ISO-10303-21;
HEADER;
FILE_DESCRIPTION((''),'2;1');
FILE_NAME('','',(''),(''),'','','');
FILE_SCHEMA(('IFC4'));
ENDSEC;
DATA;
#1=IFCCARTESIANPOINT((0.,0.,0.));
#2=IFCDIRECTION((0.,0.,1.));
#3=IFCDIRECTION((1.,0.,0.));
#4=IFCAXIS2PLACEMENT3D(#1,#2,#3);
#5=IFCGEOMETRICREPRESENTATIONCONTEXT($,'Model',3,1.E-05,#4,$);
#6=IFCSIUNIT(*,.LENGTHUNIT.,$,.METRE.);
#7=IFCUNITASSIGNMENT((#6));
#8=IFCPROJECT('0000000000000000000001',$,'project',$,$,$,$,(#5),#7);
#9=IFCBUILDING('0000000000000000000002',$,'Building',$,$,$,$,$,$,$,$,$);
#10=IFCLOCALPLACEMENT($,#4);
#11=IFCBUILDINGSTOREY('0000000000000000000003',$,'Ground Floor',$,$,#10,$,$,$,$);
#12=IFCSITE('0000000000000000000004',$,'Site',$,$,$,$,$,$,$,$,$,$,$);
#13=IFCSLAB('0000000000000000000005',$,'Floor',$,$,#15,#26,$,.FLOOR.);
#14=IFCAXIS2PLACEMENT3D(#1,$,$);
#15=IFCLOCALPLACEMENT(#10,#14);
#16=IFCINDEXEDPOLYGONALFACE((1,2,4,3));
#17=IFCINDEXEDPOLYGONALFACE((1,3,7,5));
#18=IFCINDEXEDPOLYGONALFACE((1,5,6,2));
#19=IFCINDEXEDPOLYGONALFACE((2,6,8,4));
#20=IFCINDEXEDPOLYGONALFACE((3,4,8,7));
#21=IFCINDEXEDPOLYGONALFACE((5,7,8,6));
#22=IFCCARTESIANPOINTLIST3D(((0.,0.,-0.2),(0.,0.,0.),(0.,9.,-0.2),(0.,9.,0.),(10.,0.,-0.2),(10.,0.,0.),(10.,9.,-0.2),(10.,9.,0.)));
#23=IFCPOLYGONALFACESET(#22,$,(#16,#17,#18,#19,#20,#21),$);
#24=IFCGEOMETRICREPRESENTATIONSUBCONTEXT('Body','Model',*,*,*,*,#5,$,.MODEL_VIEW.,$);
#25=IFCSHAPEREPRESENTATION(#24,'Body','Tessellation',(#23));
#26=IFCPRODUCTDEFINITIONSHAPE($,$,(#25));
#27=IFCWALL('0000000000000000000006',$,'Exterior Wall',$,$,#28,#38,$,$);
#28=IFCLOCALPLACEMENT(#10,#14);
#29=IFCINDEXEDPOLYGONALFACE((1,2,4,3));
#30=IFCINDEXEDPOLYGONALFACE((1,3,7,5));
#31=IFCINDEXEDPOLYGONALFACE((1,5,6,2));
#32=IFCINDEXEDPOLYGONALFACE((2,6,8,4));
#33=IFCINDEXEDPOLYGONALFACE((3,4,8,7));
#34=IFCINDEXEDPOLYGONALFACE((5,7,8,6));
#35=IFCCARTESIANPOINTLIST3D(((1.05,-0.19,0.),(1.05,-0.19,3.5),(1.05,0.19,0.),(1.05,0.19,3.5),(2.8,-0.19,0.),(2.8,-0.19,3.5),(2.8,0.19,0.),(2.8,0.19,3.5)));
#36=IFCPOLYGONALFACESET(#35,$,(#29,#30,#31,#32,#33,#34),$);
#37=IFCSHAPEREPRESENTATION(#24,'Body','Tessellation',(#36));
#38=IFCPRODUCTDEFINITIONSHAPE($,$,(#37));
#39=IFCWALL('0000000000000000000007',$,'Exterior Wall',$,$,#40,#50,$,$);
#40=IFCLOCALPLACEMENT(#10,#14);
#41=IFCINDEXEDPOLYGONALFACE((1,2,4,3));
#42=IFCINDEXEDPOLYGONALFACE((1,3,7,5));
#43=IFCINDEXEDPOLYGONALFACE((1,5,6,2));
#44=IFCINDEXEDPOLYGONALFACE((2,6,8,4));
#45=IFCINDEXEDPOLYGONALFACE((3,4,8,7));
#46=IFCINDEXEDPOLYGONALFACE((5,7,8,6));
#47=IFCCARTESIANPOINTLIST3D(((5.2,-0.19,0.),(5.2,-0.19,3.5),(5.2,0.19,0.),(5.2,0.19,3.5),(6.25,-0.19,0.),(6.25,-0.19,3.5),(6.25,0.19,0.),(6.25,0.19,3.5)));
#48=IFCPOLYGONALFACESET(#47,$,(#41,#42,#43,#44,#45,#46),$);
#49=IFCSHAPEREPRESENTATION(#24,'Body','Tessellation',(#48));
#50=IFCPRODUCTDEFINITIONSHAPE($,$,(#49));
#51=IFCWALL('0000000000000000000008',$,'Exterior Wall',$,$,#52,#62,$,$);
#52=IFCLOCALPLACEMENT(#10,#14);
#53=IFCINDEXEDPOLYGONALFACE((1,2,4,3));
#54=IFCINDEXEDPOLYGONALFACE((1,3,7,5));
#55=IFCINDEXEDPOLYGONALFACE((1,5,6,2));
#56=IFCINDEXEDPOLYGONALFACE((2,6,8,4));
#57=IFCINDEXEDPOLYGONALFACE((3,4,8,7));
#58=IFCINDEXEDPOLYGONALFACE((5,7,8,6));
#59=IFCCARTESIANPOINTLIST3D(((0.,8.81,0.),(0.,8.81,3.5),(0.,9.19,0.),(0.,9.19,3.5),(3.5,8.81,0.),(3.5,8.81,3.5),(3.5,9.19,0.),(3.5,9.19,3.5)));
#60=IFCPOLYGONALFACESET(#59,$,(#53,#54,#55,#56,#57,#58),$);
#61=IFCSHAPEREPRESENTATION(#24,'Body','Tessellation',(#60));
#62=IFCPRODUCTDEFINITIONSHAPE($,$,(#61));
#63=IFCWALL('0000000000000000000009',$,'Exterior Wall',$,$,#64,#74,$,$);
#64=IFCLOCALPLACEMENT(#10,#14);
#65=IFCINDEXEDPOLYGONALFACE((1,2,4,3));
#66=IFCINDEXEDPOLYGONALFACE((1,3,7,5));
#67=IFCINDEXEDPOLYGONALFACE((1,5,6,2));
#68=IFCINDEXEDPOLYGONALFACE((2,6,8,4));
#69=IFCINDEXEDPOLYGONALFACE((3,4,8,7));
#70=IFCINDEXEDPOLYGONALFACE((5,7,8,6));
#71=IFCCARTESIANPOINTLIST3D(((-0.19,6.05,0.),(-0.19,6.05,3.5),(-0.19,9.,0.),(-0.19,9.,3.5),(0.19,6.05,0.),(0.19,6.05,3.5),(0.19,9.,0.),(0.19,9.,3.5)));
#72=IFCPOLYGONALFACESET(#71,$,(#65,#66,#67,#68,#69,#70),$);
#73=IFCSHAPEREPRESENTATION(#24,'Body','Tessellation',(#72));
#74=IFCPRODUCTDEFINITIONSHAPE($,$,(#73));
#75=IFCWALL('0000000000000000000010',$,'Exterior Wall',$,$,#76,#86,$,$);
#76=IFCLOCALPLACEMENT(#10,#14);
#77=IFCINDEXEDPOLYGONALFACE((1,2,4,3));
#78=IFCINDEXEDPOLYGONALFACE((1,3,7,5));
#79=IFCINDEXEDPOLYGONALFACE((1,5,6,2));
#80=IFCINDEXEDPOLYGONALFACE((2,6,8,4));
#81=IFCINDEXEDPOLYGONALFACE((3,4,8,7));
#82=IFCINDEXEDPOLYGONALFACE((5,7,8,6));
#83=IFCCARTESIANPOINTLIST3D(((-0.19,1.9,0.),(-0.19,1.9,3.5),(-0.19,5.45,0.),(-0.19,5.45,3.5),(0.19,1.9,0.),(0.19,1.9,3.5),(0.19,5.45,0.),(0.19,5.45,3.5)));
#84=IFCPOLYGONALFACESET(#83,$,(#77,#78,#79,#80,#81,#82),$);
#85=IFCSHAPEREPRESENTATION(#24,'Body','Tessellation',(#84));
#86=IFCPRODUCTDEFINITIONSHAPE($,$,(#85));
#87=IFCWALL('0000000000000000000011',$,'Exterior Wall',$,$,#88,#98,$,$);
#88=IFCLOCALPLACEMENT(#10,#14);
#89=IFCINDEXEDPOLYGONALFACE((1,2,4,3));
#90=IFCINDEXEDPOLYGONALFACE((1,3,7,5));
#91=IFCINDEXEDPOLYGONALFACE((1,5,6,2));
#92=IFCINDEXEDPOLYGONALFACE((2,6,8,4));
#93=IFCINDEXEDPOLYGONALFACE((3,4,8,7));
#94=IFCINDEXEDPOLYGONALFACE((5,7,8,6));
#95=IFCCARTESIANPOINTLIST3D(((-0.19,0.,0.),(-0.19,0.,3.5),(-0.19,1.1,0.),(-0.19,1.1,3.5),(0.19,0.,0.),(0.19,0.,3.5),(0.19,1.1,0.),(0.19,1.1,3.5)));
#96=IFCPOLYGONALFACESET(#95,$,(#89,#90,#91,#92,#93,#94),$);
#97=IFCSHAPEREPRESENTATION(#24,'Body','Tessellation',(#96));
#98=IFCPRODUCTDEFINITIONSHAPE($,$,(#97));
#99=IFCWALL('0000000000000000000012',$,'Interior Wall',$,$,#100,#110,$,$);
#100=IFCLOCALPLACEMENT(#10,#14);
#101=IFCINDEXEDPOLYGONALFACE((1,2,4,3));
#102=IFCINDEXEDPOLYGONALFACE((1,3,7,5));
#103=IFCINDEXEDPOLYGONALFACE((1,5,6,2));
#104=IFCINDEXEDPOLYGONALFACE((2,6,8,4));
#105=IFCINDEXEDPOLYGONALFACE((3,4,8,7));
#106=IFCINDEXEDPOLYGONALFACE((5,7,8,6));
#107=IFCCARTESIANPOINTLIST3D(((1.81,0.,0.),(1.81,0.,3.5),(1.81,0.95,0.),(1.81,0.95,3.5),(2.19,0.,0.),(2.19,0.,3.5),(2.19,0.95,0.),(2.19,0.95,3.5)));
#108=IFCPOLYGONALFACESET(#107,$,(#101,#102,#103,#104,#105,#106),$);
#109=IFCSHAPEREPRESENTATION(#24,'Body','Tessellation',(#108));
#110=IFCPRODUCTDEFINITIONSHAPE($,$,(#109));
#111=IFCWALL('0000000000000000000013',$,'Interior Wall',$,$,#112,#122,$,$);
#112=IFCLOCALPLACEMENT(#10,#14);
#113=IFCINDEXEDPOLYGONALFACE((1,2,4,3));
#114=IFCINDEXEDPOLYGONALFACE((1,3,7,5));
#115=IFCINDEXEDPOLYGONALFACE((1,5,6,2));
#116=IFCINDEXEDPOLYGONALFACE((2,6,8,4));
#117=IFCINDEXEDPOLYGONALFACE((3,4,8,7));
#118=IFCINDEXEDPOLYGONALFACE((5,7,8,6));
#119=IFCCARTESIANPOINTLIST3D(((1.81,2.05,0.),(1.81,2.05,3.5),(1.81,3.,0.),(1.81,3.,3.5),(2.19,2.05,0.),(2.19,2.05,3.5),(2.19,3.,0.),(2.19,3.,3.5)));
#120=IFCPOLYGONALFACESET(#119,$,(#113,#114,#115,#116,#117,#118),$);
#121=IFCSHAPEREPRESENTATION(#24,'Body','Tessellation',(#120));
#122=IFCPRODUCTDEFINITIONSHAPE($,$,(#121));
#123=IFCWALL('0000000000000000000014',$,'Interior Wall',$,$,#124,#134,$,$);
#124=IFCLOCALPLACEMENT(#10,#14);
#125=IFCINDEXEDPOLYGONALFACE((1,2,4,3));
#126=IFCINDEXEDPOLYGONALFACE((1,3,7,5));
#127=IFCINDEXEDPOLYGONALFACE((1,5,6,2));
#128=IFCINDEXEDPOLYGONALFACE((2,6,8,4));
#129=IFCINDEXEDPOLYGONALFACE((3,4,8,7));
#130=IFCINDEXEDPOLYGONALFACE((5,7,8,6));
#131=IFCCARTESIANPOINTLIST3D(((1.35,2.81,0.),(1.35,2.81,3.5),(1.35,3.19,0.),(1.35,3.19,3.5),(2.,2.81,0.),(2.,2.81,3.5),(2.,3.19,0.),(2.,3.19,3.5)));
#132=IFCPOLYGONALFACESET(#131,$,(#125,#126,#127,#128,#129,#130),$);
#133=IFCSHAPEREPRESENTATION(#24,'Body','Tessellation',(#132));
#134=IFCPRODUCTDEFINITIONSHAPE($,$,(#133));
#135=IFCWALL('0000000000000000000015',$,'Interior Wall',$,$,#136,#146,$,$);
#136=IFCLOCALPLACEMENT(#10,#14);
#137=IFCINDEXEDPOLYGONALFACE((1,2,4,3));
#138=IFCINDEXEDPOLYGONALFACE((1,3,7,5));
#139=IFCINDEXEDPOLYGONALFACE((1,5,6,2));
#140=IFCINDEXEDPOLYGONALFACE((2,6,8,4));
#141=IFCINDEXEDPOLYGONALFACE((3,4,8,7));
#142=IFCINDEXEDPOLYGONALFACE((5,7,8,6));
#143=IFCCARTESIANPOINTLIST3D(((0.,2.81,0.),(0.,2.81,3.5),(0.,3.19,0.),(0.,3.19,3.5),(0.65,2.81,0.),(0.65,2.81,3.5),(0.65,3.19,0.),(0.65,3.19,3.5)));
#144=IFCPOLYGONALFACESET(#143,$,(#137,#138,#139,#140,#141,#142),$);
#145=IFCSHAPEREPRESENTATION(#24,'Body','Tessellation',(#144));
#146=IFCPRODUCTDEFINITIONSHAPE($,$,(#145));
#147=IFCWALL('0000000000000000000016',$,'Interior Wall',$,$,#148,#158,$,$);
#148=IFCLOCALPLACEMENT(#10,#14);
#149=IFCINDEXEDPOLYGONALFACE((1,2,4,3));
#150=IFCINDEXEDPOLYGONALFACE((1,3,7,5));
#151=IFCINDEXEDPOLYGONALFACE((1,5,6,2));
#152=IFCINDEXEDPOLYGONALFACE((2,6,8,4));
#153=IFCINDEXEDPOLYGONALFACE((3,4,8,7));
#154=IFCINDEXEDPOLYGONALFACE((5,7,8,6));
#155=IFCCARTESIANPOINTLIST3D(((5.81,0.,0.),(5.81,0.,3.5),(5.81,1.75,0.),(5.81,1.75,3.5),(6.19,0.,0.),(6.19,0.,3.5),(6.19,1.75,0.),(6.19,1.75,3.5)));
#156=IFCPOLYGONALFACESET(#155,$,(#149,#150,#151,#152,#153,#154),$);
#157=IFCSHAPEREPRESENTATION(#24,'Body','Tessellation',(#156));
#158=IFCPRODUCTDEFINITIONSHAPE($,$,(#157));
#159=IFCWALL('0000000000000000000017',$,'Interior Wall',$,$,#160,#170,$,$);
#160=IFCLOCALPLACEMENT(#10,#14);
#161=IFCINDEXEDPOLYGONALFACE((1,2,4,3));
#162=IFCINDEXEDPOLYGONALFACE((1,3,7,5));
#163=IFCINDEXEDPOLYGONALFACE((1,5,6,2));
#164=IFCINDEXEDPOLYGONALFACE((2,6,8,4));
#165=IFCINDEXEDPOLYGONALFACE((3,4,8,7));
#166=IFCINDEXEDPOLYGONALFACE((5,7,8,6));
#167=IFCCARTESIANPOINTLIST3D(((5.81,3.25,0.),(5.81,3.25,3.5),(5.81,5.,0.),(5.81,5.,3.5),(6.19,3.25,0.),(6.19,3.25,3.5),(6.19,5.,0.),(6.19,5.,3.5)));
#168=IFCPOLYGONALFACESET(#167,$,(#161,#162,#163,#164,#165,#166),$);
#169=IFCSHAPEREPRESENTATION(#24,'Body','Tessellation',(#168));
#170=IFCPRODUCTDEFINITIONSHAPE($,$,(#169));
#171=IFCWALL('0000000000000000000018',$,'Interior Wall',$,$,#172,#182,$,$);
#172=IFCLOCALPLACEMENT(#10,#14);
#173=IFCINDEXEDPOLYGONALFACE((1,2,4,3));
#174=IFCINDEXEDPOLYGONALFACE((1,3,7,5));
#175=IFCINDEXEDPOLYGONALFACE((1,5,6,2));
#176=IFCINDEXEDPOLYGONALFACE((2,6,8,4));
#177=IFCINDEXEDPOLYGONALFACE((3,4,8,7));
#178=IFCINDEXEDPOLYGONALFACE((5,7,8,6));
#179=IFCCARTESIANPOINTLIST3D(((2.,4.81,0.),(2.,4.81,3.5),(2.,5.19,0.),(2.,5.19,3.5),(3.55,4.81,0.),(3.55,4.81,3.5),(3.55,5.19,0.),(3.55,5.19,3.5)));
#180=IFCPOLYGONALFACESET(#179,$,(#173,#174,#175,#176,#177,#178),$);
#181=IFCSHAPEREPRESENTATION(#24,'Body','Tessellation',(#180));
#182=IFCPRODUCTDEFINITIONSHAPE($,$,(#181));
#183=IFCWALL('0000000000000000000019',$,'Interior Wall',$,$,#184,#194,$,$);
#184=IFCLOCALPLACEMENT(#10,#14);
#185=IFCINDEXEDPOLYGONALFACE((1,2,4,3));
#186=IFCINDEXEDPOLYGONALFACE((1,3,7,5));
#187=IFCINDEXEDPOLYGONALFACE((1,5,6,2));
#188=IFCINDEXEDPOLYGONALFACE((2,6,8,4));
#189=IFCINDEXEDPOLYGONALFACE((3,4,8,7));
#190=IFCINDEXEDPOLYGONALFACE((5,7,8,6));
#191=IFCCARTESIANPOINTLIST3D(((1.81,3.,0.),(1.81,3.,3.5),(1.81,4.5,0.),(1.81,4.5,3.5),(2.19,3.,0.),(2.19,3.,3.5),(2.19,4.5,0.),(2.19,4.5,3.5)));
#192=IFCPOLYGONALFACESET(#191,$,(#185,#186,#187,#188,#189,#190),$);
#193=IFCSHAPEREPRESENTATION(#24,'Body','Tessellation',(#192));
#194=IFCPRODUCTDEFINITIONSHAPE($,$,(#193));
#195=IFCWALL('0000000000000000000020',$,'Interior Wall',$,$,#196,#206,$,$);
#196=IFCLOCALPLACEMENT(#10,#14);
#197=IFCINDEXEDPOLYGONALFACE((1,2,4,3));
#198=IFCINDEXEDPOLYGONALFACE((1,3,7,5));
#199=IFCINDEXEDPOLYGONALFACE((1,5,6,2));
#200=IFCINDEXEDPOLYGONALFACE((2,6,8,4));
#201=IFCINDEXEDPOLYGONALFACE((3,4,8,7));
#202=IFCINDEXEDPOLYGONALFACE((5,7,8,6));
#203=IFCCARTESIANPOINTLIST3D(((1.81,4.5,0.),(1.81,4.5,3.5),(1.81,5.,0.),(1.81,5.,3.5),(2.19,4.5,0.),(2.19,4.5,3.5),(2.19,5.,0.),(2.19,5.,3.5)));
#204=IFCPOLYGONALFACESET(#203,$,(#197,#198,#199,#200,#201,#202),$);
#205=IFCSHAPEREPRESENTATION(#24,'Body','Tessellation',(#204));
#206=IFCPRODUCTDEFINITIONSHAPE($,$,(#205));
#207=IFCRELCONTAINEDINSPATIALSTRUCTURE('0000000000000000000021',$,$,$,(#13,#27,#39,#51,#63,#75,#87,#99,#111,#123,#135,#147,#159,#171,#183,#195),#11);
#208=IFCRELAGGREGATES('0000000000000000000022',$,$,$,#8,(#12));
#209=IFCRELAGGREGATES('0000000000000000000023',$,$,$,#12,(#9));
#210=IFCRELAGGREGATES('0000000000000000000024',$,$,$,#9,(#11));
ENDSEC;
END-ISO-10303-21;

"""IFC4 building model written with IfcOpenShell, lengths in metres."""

from ifc_helpers import new_model, si_unit, frame, origin_with_axes, place, context, subcontext, project, spatial, indexed_curve, outline, extrude, element, save


model = new_model("IFC4")

# Units and contexts
model_context = context("Model", 3, precision=1e-05, world=origin_with_axes())
body_context = subcontext(model_context, "Body", "Model", "MODEL_VIEW")
ifc_project = project(units=[si_unit("LENGTHUNIT", "METRE")], contexts=[model_context])

# Site, building, storey
site = spatial("IfcSite", under=ifc_project, Name="Site")
building = spatial("IfcBuilding", under=site, Name="Building")
storey_placement = place(None, origin_with_axes())
storey = spatial("IfcBuildingStorey", under=building, at=storey_placement, Name="Ground Floor")

# Slab
slab_placement = place(storey_placement, frame((0.0, 0.0, -0.2), z_axis=(0.0, 0.0, 1.0), x_axis=(1.0, 0.0, 0.0)))
element("IfcSlab", 1, at=slab_placement, inside=storey, Name="Floor", PredefinedType="FLOOR", context=body_context, shape_type="SweptSolid", body=[
    extrude(outline(indexed_curve([(0.0, 0.0), (10.0, 0.0), (10.0, 9.0), (0.0, 9.0)])), None, (0.0, 0.0, 1.0), 0.2),
])

# Walls
wall_1_placement = place(storey_placement, frame((1.05, 0.0, 0.0), z_axis=(0.0, 0.0, 1.0), x_axis=(1.0, 0.0, 0.0)))
element("IfcWall", 2, at=wall_1_placement, inside=storey, Name="Exterior Wall", context=body_context, shape_type="SweptSolid", body=[
    extrude(outline(indexed_curve([(0.0, 0.0), (0.0, 0.38), (1.75, 0.38), (1.75, 0.0), (0.0, 0.0)], self_intersect=False)), frame((0.0, -0.19, 0.0), z_axis=(0.0, 0.0, 1.0), x_axis=(1.0, 0.0, 0.0)), (0.0, 0.0, 1.0), 3.5),
])
wall_2_placement = place(storey_placement, frame((5.2, 0.0, 0.0), z_axis=(0.0, 0.0, 1.0), x_axis=(1.0, 0.0, 0.0)))
element("IfcWall", 3, at=wall_2_placement, inside=storey, Name="Exterior Wall", context=body_context, shape_type="SweptSolid", body=[
    extrude(outline(indexed_curve([(0.0, 0.0), (0.0, 0.38), (1.05, 0.38), (1.05, 0.0), (0.0, 0.0)], self_intersect=False)), frame((0.0, -0.19, 0.0), z_axis=(0.0, 0.0, 1.0), x_axis=(1.0, 0.0, 0.0)), (0.0, 0.0, 1.0), 3.5),
])
wall_3_placement = place(storey_placement, frame((3.5, 9.0, 0.0), z_axis=(0.0, 0.0, 1.0), x_axis=(-1.0, 0.0, 0.0)))
element("IfcWall", 4, at=wall_3_placement, inside=storey, Name="Exterior Wall", context=body_context, shape_type="SweptSolid", body=[
    extrude(outline(indexed_curve([(0.0, 0.0), (0.0, 0.38), (3.5, 0.38), (3.5, 0.0), (0.0, 0.0)], self_intersect=False)), frame((0.0, -0.19, 0.0), z_axis=(0.0, 0.0, 1.0), x_axis=(1.0, 0.0, 0.0)), (0.0, 0.0, 1.0), 3.5),
])
wall_4_placement = place(storey_placement, frame((0.0, 9.0, 0.0), z_axis=(0.0, 0.0, 1.0), x_axis=(0.0, -1.0, 0.0)))
element("IfcWall", 5, at=wall_4_placement, inside=storey, Name="Exterior Wall", context=body_context, shape_type="SweptSolid", body=[
    extrude(outline(indexed_curve([(0.0, 0.0), (0.0, 0.38), (2.95, 0.38), (2.95, 0.0), (0.0, 0.0)], self_intersect=False)), frame((0.0, -0.19, 0.0), z_axis=(0.0, 0.0, 1.0), x_axis=(1.0, 0.0, 0.0)), (0.0, 0.0, 1.0), 3.5),
])
wall_5_placement = place(storey_placement, frame((0.0, 5.45, 0.0), z_axis=(0.0, 0.0, 1.0), x_axis=(0.0, -1.0, 0.0)))
element("IfcWall", 6, at=wall_5_placement, inside=storey, Name="Exterior Wall", context=body_context, shape_type="SweptSolid", body=[
    extrude(outline(indexed_curve([(0.0, 0.0), (0.0, 0.38), (3.55, 0.38), (3.55, 0.0), (0.0, 0.0)], self_intersect=False)), frame((0.0, -0.19, 0.0), z_axis=(0.0, 0.0, 1.0), x_axis=(1.0, 0.0, 0.0)), (0.0, 0.0, 1.0), 3.5),
])
wall_6_placement = place(storey_placement, frame((0.0, 1.1, 0.0), z_axis=(0.0, 0.0, 1.0), x_axis=(0.0, -1.0, 0.0)))
element("IfcWall", 7, at=wall_6_placement, inside=storey, Name="Exterior Wall", context=body_context, shape_type="SweptSolid", body=[
    extrude(outline(indexed_curve([(0.0, 0.0), (0.0, 0.38), (1.1, 0.38), (1.1, 0.0), (0.0, 0.0)], self_intersect=False)), frame((0.0, -0.19, 0.0), z_axis=(0.0, 0.0, 1.0), x_axis=(1.0, 0.0, 0.0)), (0.0, 0.0, 1.0), 3.5),
])
wall_7_placement = place(storey_placement, frame((2.0, 0.0, 0.0), z_axis=(0.0, 0.0, 1.0), x_axis=(0.0, 1.0, 0.0)))
element("IfcWall", 8, at=wall_7_placement, inside=storey, Name="Interior Wall", context=body_context, shape_type="SweptSolid", body=[
    extrude(outline(indexed_curve([(0.0, 0.0), (0.0, 0.38), (0.95, 0.38), (0.95, 0.0), (0.0, 0.0)], self_intersect=False)), frame((0.0, -0.19, 0.0), z_axis=(0.0, 0.0, 1.0), x_axis=(1.0, 0.0, 0.0)), (0.0, 0.0, 1.0), 3.5),
])
wall_8_placement = place(storey_placement, frame((2.0, 2.05, 0.0), z_axis=(0.0, 0.0, 1.0), x_axis=(0.0, 1.0, 0.0)))
element("IfcWall", 9, at=wall_8_placement, inside=storey, Name="Interior Wall", context=body_context, shape_type="SweptSolid", body=[
    extrude(outline(indexed_curve([(0.0, 0.0), (0.0, 0.38), (0.95, 0.38), (0.95, 0.0), (0.0, 0.0)], self_intersect=False)), frame((0.0, -0.19, 0.0), z_axis=(0.0, 0.0, 1.0), x_axis=(1.0, 0.0, 0.0)), (0.0, 0.0, 1.0), 3.5),
])
for number, where, z_axis, x_axis, name in (
    (10, (2.0, 3.0, 0.0), (0.0, 0.0, 1.0), (-1.0, 0.0, 0.0), "Interior Wall"),
    (11, (0.65, 3.0, 0.0), (0.0, 0.0, 1.0), (-1.0, 0.0, 0.0), "Interior Wall"),
):
    element("IfcWall", number, at=place(storey_placement, frame(where, z_axis=z_axis, x_axis=x_axis)), inside=storey, Name=name, context=body_context, shape_type="SweptSolid", body=[
        extrude(outline(indexed_curve([(0.0, 0.0), (0.0, 0.38), (0.65, 0.38), (0.65, 0.0), (0.0, 0.0)], self_intersect=False)), frame((0.0, -0.19, 0.0), z_axis=(0.0, 0.0, 1.0), x_axis=(1.0, 0.0, 0.0)), (0.0, 0.0, 1.0), 3.5),
    ])
for number, where, z_axis, x_axis, name in (
    (12, (6.0, 0.0, 0.0), (0.0, 0.0, 1.0), (0.0, 1.0, 0.0), "Interior Wall"),
    (13, (6.0, 3.25, 0.0), (0.0, 0.0, 1.0), (0.0, 1.0, 0.0), "Interior Wall"),
):
    element("IfcWall", number, at=place(storey_placement, frame(where, z_axis=z_axis, x_axis=x_axis)), inside=storey, Name=name, context=body_context, shape_type="SweptSolid", body=[
        extrude(outline(indexed_curve([(0.0, 0.0), (0.0, 0.38), (1.75, 0.38), (1.75, 0.0), (0.0, 0.0)], self_intersect=False)), frame((0.0, -0.19, 0.0), z_axis=(0.0, 0.0, 1.0), x_axis=(1.0, 0.0, 0.0)), (0.0, 0.0, 1.0), 3.5),
    ])
wall_9_placement = place(storey_placement, frame((3.55, 5.0, 0.0), z_axis=(0.0, 0.0, 1.0), x_axis=(-1.0, 0.0, 0.0)))
element("IfcWall", 14, at=wall_9_placement, inside=storey, Name="Interior Wall", context=body_context, shape_type="SweptSolid", body=[
    extrude(outline(indexed_curve([(0.0, 0.0), (0.0, 0.38), (1.55, 0.38), (1.55, 0.0), (0.0, 0.0)], self_intersect=False)), frame((0.0, -0.19, 0.0), z_axis=(0.0, 0.0, 1.0), x_axis=(1.0, 0.0, 0.0)), (0.0, 0.0, 1.0), 3.5),
])
wall_10_placement = place(storey_placement, frame((2.0, 4.5, 0.0), z_axis=(0.0, 0.0, 1.0), x_axis=(0.0, -1.0, 0.0)))
element("IfcWall", 15, at=wall_10_placement, inside=storey, Name="Interior Wall", context=body_context, shape_type="SweptSolid", body=[
    extrude(outline(indexed_curve([(0.0, 0.0), (0.0, 0.38), (1.5, 0.38), (1.5, 0.0), (0.0, 0.0)], self_intersect=False)), frame((0.0, -0.19, 0.0), z_axis=(0.0, 0.0, 1.0), x_axis=(1.0, 0.0, 0.0)), (0.0, 0.0, 1.0), 3.5),
])
wall_11_placement = place(storey_placement, frame((2.0, 5.0, 0.0), z_axis=(0.0, 0.0, 1.0), x_axis=(0.0, -1.0, 0.0)))
element("IfcWall", 16, at=wall_11_placement, inside=storey, Name="Interior Wall", context=body_context, shape_type="SweptSolid", body=[
    extrude(outline(indexed_curve([(0.0, 0.0), (0.0, 0.38), (0.5, 0.38), (0.5, 0.0), (0.0, 0.0)], self_intersect=False)), frame((0.0, -0.19, 0.0), z_axis=(0.0, 0.0, 1.0), x_axis=(1.0, 0.0, 0.0)), (0.0, 0.0, 1.0), 3.5),
])

save(model, "model.ifc")
